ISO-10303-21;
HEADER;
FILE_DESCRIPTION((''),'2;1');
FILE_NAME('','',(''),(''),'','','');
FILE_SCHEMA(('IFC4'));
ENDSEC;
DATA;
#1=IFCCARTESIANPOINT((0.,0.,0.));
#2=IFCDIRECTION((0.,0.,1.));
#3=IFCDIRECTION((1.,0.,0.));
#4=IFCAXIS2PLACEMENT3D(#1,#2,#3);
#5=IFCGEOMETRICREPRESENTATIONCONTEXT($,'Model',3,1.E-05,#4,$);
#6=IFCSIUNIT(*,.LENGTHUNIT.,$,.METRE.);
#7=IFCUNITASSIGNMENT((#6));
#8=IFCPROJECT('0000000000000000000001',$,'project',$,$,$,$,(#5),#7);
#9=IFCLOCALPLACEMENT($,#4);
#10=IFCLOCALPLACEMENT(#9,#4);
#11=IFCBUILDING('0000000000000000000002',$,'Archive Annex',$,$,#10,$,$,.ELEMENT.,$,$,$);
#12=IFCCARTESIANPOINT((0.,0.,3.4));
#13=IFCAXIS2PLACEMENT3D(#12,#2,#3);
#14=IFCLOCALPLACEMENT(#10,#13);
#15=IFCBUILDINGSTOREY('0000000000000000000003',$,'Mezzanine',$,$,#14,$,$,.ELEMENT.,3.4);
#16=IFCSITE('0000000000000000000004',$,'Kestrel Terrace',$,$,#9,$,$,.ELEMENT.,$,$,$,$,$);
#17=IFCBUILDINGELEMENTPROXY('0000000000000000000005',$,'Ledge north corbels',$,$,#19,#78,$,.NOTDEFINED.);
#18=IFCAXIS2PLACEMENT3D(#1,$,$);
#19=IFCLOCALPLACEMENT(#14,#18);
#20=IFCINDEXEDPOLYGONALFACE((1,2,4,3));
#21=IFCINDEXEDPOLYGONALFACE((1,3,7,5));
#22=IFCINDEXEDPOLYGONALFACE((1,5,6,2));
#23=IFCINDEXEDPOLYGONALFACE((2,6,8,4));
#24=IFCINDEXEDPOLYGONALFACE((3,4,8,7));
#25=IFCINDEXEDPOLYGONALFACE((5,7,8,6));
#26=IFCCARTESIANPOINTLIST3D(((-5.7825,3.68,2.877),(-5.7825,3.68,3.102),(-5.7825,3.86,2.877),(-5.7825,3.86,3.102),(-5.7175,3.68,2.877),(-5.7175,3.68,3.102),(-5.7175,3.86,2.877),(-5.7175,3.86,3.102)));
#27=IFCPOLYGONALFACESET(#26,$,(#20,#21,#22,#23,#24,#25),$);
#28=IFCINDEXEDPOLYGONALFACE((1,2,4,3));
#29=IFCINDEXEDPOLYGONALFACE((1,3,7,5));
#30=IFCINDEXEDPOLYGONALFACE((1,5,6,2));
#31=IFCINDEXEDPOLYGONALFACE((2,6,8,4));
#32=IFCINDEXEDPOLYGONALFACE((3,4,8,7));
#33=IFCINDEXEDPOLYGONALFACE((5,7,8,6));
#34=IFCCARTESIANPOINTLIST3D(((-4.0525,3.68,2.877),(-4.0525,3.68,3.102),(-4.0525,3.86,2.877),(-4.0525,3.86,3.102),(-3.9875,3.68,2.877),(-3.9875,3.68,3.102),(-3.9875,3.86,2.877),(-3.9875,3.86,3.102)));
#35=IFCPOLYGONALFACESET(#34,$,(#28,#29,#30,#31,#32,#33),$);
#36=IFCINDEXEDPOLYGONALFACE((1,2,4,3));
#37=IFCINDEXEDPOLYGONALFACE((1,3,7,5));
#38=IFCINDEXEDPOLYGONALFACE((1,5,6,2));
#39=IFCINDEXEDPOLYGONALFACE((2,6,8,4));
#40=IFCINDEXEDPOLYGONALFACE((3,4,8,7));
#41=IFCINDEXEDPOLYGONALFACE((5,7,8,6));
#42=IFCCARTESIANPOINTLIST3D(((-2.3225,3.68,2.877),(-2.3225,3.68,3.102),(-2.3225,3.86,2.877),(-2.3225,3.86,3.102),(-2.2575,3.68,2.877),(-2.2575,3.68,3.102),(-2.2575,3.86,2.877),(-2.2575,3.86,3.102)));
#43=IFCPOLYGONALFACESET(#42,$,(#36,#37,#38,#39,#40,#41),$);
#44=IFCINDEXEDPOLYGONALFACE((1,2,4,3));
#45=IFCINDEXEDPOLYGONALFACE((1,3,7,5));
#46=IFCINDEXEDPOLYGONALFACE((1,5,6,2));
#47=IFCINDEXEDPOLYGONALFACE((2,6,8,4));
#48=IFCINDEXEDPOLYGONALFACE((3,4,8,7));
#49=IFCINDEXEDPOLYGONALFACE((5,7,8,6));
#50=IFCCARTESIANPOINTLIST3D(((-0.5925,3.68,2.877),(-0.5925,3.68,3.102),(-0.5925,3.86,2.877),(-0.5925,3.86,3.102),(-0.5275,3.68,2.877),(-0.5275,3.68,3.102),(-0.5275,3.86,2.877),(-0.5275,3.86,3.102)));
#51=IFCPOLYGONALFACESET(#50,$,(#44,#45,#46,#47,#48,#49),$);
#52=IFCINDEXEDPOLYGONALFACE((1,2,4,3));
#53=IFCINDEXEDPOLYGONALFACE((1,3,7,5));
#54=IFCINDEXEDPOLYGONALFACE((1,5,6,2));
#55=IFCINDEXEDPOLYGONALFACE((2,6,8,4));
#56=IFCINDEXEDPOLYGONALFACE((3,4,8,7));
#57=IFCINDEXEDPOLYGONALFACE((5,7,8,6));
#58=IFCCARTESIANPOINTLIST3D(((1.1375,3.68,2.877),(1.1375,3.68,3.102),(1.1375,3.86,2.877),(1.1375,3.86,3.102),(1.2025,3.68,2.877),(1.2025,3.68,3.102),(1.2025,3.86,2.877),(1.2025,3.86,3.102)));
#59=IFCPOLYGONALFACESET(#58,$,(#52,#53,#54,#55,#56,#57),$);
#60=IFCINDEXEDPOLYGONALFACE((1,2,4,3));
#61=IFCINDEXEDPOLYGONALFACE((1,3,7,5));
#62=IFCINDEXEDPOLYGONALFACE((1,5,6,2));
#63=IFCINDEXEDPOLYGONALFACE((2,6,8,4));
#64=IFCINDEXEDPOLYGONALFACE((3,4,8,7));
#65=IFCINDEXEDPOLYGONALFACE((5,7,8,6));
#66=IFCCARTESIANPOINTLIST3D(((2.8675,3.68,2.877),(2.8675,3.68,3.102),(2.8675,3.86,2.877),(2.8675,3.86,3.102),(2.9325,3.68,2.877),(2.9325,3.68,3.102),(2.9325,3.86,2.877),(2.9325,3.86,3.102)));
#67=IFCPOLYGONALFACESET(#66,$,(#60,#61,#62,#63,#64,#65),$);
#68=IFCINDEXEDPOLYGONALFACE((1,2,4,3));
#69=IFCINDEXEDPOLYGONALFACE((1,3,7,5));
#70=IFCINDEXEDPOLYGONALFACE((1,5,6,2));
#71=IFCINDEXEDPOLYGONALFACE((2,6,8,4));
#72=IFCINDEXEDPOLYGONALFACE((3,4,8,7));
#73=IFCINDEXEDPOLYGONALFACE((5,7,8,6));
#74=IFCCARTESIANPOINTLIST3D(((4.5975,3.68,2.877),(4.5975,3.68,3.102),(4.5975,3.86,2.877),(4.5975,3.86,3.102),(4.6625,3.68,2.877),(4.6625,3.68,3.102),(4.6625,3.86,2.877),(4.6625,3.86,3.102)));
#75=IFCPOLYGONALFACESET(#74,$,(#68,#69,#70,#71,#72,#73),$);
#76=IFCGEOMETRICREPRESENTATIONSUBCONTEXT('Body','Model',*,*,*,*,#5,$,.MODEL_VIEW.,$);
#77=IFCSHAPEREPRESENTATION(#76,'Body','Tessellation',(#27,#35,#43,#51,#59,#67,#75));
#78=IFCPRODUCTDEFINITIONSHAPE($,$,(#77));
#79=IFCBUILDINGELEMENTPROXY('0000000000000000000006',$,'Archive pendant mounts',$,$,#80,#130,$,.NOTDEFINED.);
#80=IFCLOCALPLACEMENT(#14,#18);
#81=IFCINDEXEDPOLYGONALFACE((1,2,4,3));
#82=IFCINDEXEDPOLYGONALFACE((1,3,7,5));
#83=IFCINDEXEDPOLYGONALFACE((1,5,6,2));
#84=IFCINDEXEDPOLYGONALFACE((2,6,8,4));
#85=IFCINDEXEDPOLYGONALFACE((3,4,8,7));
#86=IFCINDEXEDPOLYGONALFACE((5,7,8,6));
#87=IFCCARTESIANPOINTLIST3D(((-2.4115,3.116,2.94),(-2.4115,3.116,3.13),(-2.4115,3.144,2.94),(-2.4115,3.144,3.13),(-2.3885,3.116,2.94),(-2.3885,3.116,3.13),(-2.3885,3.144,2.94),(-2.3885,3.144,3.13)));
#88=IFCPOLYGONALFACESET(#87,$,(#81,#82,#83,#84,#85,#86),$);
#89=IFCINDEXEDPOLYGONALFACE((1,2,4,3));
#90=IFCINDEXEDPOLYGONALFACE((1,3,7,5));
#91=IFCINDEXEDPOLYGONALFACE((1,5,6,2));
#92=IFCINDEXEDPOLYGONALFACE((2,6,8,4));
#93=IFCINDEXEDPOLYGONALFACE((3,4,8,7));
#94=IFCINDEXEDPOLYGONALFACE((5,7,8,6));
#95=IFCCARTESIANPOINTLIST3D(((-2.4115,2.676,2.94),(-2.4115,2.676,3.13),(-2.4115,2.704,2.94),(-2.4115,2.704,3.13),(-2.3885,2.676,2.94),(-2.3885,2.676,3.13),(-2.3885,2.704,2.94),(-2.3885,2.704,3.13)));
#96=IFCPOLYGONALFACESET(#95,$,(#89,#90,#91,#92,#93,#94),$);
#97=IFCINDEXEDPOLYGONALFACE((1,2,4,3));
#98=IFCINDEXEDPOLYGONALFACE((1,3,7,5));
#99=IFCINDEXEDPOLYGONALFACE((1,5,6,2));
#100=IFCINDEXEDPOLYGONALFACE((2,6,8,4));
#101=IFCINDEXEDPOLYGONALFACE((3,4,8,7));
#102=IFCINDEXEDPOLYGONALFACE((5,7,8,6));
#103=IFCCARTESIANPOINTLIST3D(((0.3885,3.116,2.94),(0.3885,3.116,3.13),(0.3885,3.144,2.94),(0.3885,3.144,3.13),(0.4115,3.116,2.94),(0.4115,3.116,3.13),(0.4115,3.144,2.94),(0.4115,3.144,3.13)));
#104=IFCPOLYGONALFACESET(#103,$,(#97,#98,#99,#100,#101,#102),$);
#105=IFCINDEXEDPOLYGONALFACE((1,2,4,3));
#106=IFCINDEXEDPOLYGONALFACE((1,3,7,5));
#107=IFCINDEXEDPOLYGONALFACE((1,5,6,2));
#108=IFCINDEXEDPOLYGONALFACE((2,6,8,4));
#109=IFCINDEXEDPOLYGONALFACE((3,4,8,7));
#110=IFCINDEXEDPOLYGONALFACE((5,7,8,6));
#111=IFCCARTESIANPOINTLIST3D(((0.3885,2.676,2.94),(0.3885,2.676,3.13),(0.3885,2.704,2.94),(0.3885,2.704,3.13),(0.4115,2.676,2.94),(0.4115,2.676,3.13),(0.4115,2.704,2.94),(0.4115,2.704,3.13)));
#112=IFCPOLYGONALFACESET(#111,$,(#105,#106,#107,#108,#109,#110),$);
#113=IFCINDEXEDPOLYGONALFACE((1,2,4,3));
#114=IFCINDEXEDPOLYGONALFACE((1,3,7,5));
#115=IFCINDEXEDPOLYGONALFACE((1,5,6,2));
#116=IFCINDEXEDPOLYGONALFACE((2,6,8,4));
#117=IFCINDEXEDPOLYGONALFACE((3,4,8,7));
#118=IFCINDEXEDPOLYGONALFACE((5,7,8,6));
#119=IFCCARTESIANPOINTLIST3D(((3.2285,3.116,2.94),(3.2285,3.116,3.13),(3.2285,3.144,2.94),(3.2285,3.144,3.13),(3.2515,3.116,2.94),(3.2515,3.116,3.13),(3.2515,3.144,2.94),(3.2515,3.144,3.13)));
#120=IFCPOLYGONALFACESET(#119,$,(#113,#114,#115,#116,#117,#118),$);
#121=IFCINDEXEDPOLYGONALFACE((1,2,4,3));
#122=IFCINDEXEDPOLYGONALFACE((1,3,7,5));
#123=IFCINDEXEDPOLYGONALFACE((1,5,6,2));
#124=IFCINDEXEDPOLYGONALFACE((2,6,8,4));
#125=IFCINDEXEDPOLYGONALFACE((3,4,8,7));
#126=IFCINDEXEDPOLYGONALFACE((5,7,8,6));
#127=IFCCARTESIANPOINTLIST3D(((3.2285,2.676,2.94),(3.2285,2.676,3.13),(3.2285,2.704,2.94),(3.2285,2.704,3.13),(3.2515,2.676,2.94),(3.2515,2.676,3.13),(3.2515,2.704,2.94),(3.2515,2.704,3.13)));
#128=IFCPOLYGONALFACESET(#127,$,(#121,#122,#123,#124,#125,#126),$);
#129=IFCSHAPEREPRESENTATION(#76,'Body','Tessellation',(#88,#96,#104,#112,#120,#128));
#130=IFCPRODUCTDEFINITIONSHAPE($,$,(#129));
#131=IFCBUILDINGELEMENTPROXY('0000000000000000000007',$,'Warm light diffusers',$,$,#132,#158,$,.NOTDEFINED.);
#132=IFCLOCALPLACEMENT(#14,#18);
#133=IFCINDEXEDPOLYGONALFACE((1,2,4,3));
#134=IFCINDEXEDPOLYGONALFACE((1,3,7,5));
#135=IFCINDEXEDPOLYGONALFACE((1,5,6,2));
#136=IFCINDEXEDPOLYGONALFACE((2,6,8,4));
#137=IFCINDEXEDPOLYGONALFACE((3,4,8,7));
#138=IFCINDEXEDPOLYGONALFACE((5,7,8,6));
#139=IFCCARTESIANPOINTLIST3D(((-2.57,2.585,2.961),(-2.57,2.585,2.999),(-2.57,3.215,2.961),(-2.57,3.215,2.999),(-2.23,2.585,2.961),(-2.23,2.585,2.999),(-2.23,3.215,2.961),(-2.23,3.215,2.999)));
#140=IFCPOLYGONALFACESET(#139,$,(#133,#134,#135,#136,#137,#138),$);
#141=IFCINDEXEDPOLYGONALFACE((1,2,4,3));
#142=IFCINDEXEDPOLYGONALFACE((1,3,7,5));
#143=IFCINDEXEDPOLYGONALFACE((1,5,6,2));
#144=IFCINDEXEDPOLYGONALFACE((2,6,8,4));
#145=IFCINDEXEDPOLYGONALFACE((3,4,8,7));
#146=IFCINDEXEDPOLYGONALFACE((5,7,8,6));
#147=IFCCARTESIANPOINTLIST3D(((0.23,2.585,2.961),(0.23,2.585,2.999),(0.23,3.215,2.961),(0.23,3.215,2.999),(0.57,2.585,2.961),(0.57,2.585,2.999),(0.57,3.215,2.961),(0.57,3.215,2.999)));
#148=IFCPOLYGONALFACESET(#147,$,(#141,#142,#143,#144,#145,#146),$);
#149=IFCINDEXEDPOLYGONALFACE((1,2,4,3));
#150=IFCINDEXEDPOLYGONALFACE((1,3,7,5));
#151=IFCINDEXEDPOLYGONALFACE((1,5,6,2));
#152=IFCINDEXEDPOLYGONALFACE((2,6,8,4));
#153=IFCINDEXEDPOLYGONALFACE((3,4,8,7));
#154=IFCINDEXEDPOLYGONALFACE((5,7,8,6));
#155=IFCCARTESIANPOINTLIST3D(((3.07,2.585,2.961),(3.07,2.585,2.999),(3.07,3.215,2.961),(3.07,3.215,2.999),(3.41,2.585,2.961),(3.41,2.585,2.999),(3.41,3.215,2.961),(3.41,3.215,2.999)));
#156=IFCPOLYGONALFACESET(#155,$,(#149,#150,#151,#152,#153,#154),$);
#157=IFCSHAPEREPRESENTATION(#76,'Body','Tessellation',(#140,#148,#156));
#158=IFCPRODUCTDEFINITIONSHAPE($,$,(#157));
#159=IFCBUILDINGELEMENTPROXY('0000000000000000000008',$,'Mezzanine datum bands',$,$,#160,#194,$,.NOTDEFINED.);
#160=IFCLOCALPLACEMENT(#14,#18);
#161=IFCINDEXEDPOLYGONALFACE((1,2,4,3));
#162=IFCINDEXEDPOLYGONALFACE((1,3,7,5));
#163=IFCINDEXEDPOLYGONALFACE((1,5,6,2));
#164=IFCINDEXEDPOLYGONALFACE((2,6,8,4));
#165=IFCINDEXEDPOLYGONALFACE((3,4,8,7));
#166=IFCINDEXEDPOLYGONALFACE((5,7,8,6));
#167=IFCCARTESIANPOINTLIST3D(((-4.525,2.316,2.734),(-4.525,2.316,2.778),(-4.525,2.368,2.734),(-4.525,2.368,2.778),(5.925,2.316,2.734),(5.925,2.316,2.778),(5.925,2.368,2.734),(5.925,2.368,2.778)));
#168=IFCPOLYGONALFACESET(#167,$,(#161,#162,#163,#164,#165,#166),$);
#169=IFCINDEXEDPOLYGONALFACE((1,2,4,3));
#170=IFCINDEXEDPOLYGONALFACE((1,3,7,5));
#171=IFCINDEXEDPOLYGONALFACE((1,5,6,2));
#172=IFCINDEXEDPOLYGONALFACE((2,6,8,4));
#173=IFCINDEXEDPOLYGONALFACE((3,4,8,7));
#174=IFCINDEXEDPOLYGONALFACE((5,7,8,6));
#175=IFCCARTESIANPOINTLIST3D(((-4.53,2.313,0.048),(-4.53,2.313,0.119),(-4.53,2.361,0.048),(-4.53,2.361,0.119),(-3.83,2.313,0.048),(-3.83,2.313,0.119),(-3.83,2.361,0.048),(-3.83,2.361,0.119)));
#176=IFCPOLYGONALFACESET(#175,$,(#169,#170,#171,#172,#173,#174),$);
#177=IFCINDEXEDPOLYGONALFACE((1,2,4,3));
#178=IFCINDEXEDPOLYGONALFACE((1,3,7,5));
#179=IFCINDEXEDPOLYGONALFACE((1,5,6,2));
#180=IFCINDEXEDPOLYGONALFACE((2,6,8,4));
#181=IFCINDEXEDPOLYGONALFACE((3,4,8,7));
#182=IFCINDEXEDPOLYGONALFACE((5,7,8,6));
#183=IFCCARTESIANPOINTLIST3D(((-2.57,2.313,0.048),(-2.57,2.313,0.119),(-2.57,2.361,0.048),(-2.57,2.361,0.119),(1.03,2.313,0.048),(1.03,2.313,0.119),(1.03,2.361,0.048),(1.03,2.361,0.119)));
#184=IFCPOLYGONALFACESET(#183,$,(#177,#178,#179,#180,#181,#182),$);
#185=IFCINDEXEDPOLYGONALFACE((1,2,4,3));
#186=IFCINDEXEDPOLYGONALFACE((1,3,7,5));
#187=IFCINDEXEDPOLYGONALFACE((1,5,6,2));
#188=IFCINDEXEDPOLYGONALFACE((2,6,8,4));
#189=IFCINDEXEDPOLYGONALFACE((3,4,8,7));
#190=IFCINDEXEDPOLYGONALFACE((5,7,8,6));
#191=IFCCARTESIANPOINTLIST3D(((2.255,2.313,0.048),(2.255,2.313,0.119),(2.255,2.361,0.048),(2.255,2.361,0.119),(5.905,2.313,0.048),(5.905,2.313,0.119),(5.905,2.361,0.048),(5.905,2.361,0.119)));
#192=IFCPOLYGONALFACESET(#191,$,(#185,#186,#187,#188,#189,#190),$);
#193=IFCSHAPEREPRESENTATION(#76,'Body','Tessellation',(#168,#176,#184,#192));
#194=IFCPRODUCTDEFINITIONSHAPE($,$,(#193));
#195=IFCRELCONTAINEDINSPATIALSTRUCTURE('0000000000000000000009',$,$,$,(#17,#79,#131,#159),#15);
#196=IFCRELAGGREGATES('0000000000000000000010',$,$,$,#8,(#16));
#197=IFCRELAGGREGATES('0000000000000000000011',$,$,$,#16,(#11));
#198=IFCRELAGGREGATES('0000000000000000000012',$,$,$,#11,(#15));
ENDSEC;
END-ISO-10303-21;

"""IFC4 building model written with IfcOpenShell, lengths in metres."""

from ifc_helpers import new_model, si_unit, frame, origin_with_axes, origin_2d, place, context, subcontext, project, spatial, rectangle, extrude, element, save


model = new_model("IFC4")

# Units and contexts
model_context = context("Model", 3, precision=1e-05, world=origin_with_axes())
body_context = subcontext(model_context, "Body", "Model", "MODEL_VIEW")
ifc_project = project(units=[si_unit("LENGTHUNIT", "METRE")], contexts=[model_context])

# Site, building, storey
site_placement = place(None, origin_with_axes())
site = spatial("IfcSite", under=ifc_project, at=site_placement, Name="Kestrel Terrace", CompositionType="ELEMENT")
building_placement = place(site_placement, origin_with_axes())
building = spatial("IfcBuilding", under=site, at=building_placement, Name="Archive Annex", CompositionType="ELEMENT")
storey_placement = place(building_placement, frame((0.0, 0.0, 3.4), z_axis=(0.0, 0.0, 1.0), x_axis=(1.0, 0.0, 0.0)))
storey = spatial("IfcBuildingStorey", under=building, at=storey_placement, Name="Mezzanine", CompositionType="ELEMENT", Elevation=3.4)

# Building element proxies
proxy_1_placement = place(storey_placement, origin_with_axes())
element("IfcBuildingElementProxy", 1, at=proxy_1_placement, inside=storey, Name="Ledge north corbels", PredefinedType="NOTDEFINED", context=body_context, shape_type="SweptSolid", body=[
    extrude(rectangle(XDim=0.065, YDim=0.18, at=origin_2d()), frame((-5.75, 3.77, 2.877), z_axis=(0.0, 0.0, 1.0), x_axis=(1.0, 0.0, 0.0)), (0.0, 0.0, 1.0), 0.225),
    extrude(rectangle(XDim=0.065, YDim=0.18, at=origin_2d()), frame((-4.02, 3.77, 2.877), z_axis=(0.0, 0.0, 1.0), x_axis=(1.0, 0.0, 0.0)), (0.0, 0.0, 1.0), 0.225),
    extrude(rectangle(XDim=0.065, YDim=0.18, at=origin_2d()), frame((-2.29, 3.77, 2.877), z_axis=(0.0, 0.0, 1.0), x_axis=(1.0, 0.0, 0.0)), (0.0, 0.0, 1.0), 0.225),
    extrude(rectangle(XDim=0.065, YDim=0.18, at=origin_2d()), frame((-0.56, 3.77, 2.877), z_axis=(0.0, 0.0, 1.0), x_axis=(1.0, 0.0, 0.0)), (0.0, 0.0, 1.0), 0.225),
    extrude(rectangle(XDim=0.065, YDim=0.18, at=origin_2d()), frame((1.17, 3.77, 2.877), z_axis=(0.0, 0.0, 1.0), x_axis=(1.0, 0.0, 0.0)), (0.0, 0.0, 1.0), 0.225),
    extrude(rectangle(XDim=0.065, YDim=0.18, at=origin_2d()), frame((2.9, 3.77, 2.877), z_axis=(0.0, 0.0, 1.0), x_axis=(1.0, 0.0, 0.0)), (0.0, 0.0, 1.0), 0.225),
    extrude(rectangle(XDim=0.065, YDim=0.18, at=origin_2d()), frame((4.63, 3.77, 2.877), z_axis=(0.0, 0.0, 1.0), x_axis=(1.0, 0.0, 0.0)), (0.0, 0.0, 1.0), 0.225),
])
proxy_2_placement = place(storey_placement, origin_with_axes())
element("IfcBuildingElementProxy", 2, at=proxy_2_placement, inside=storey, Name="Archive pendant mounts", PredefinedType="NOTDEFINED", context=body_context, shape_type="SweptSolid", body=[
    extrude(rectangle(XDim=0.023, YDim=0.028, at=origin_2d()), frame((-2.4, 3.13, 2.94), z_axis=(0.0, 0.0, 1.0), x_axis=(1.0, 0.0, 0.0)), (0.0, 0.0, 1.0), 0.19),
    extrude(rectangle(XDim=0.023, YDim=0.028, at=origin_2d()), frame((-2.4, 2.69, 2.94), z_axis=(0.0, 0.0, 1.0), x_axis=(1.0, 0.0, 0.0)), (0.0, 0.0, 1.0), 0.19),
    extrude(rectangle(XDim=0.023, YDim=0.028, at=origin_2d()), frame((0.4, 3.13, 2.94), z_axis=(0.0, 0.0, 1.0), x_axis=(1.0, 0.0, 0.0)), (0.0, 0.0, 1.0), 0.19),
    extrude(rectangle(XDim=0.023, YDim=0.028, at=origin_2d()), frame((0.4, 2.69, 2.94), z_axis=(0.0, 0.0, 1.0), x_axis=(1.0, 0.0, 0.0)), (0.0, 0.0, 1.0), 0.19),
    extrude(rectangle(XDim=0.023, YDim=0.028, at=origin_2d()), frame((3.24, 3.13, 2.94), z_axis=(0.0, 0.0, 1.0), x_axis=(1.0, 0.0, 0.0)), (0.0, 0.0, 1.0), 0.19),
    extrude(rectangle(XDim=0.023, YDim=0.028, at=origin_2d()), frame((3.24, 2.69, 2.94), z_axis=(0.0, 0.0, 1.0), x_axis=(1.0, 0.0, 0.0)), (0.0, 0.0, 1.0), 0.19),
])
proxy_3_placement = place(storey_placement, origin_with_axes())
element("IfcBuildingElementProxy", 3, at=proxy_3_placement, inside=storey, Name="Warm light diffusers", PredefinedType="NOTDEFINED", context=body_context, shape_type="SweptSolid", body=[
    extrude(rectangle(XDim=0.34, YDim=0.63, at=origin_2d()), frame((-2.4, 2.9, 2.961), z_axis=(0.0, 0.0, 1.0), x_axis=(1.0, 0.0, 0.0)), (0.0, 0.0, 1.0), 0.038),
    extrude(rectangle(XDim=0.34, YDim=0.63, at=origin_2d()), frame((0.4, 2.9, 2.961), z_axis=(0.0, 0.0, 1.0), x_axis=(1.0, 0.0, 0.0)), (0.0, 0.0, 1.0), 0.038),
    extrude(rectangle(XDim=0.34, YDim=0.63, at=origin_2d()), frame((3.24, 2.9, 2.961), z_axis=(0.0, 0.0, 1.0), x_axis=(1.0, 0.0, 0.0)), (0.0, 0.0, 1.0), 0.038),
])
proxy_4_placement = place(storey_placement, origin_with_axes())
element("IfcBuildingElementProxy", 4, at=proxy_4_placement, inside=storey, Name="Mezzanine datum bands", PredefinedType="NOTDEFINED", context=body_context, shape_type="SweptSolid", body=[
    extrude(rectangle(XDim=10.45, YDim=0.052, at=origin_2d()), frame((0.7, 2.342, 2.734), z_axis=(0.0, 0.0, 1.0), x_axis=(1.0, 0.0, 0.0)), (0.0, 0.0, 1.0), 0.044),
    extrude(rectangle(XDim=0.7, YDim=0.048, at=origin_2d()), frame((-4.18, 2.337, 0.048), z_axis=(0.0, 0.0, 1.0), x_axis=(1.0, 0.0, 0.0)), (0.0, 0.0, 1.0), 0.071),
    extrude(rectangle(XDim=3.6, YDim=0.048, at=origin_2d()), frame((-0.77, 2.337, 0.048), z_axis=(0.0, 0.0, 1.0), x_axis=(1.0, 0.0, 0.0)), (0.0, 0.0, 1.0), 0.071),
    extrude(rectangle(XDim=3.65, YDim=0.048, at=origin_2d()), frame((4.08, 2.337, 0.048), z_axis=(0.0, 0.0, 1.0), x_axis=(1.0, 0.0, 0.0)), (0.0, 0.0, 1.0), 0.071),
])

save(model, "model.ifc")
